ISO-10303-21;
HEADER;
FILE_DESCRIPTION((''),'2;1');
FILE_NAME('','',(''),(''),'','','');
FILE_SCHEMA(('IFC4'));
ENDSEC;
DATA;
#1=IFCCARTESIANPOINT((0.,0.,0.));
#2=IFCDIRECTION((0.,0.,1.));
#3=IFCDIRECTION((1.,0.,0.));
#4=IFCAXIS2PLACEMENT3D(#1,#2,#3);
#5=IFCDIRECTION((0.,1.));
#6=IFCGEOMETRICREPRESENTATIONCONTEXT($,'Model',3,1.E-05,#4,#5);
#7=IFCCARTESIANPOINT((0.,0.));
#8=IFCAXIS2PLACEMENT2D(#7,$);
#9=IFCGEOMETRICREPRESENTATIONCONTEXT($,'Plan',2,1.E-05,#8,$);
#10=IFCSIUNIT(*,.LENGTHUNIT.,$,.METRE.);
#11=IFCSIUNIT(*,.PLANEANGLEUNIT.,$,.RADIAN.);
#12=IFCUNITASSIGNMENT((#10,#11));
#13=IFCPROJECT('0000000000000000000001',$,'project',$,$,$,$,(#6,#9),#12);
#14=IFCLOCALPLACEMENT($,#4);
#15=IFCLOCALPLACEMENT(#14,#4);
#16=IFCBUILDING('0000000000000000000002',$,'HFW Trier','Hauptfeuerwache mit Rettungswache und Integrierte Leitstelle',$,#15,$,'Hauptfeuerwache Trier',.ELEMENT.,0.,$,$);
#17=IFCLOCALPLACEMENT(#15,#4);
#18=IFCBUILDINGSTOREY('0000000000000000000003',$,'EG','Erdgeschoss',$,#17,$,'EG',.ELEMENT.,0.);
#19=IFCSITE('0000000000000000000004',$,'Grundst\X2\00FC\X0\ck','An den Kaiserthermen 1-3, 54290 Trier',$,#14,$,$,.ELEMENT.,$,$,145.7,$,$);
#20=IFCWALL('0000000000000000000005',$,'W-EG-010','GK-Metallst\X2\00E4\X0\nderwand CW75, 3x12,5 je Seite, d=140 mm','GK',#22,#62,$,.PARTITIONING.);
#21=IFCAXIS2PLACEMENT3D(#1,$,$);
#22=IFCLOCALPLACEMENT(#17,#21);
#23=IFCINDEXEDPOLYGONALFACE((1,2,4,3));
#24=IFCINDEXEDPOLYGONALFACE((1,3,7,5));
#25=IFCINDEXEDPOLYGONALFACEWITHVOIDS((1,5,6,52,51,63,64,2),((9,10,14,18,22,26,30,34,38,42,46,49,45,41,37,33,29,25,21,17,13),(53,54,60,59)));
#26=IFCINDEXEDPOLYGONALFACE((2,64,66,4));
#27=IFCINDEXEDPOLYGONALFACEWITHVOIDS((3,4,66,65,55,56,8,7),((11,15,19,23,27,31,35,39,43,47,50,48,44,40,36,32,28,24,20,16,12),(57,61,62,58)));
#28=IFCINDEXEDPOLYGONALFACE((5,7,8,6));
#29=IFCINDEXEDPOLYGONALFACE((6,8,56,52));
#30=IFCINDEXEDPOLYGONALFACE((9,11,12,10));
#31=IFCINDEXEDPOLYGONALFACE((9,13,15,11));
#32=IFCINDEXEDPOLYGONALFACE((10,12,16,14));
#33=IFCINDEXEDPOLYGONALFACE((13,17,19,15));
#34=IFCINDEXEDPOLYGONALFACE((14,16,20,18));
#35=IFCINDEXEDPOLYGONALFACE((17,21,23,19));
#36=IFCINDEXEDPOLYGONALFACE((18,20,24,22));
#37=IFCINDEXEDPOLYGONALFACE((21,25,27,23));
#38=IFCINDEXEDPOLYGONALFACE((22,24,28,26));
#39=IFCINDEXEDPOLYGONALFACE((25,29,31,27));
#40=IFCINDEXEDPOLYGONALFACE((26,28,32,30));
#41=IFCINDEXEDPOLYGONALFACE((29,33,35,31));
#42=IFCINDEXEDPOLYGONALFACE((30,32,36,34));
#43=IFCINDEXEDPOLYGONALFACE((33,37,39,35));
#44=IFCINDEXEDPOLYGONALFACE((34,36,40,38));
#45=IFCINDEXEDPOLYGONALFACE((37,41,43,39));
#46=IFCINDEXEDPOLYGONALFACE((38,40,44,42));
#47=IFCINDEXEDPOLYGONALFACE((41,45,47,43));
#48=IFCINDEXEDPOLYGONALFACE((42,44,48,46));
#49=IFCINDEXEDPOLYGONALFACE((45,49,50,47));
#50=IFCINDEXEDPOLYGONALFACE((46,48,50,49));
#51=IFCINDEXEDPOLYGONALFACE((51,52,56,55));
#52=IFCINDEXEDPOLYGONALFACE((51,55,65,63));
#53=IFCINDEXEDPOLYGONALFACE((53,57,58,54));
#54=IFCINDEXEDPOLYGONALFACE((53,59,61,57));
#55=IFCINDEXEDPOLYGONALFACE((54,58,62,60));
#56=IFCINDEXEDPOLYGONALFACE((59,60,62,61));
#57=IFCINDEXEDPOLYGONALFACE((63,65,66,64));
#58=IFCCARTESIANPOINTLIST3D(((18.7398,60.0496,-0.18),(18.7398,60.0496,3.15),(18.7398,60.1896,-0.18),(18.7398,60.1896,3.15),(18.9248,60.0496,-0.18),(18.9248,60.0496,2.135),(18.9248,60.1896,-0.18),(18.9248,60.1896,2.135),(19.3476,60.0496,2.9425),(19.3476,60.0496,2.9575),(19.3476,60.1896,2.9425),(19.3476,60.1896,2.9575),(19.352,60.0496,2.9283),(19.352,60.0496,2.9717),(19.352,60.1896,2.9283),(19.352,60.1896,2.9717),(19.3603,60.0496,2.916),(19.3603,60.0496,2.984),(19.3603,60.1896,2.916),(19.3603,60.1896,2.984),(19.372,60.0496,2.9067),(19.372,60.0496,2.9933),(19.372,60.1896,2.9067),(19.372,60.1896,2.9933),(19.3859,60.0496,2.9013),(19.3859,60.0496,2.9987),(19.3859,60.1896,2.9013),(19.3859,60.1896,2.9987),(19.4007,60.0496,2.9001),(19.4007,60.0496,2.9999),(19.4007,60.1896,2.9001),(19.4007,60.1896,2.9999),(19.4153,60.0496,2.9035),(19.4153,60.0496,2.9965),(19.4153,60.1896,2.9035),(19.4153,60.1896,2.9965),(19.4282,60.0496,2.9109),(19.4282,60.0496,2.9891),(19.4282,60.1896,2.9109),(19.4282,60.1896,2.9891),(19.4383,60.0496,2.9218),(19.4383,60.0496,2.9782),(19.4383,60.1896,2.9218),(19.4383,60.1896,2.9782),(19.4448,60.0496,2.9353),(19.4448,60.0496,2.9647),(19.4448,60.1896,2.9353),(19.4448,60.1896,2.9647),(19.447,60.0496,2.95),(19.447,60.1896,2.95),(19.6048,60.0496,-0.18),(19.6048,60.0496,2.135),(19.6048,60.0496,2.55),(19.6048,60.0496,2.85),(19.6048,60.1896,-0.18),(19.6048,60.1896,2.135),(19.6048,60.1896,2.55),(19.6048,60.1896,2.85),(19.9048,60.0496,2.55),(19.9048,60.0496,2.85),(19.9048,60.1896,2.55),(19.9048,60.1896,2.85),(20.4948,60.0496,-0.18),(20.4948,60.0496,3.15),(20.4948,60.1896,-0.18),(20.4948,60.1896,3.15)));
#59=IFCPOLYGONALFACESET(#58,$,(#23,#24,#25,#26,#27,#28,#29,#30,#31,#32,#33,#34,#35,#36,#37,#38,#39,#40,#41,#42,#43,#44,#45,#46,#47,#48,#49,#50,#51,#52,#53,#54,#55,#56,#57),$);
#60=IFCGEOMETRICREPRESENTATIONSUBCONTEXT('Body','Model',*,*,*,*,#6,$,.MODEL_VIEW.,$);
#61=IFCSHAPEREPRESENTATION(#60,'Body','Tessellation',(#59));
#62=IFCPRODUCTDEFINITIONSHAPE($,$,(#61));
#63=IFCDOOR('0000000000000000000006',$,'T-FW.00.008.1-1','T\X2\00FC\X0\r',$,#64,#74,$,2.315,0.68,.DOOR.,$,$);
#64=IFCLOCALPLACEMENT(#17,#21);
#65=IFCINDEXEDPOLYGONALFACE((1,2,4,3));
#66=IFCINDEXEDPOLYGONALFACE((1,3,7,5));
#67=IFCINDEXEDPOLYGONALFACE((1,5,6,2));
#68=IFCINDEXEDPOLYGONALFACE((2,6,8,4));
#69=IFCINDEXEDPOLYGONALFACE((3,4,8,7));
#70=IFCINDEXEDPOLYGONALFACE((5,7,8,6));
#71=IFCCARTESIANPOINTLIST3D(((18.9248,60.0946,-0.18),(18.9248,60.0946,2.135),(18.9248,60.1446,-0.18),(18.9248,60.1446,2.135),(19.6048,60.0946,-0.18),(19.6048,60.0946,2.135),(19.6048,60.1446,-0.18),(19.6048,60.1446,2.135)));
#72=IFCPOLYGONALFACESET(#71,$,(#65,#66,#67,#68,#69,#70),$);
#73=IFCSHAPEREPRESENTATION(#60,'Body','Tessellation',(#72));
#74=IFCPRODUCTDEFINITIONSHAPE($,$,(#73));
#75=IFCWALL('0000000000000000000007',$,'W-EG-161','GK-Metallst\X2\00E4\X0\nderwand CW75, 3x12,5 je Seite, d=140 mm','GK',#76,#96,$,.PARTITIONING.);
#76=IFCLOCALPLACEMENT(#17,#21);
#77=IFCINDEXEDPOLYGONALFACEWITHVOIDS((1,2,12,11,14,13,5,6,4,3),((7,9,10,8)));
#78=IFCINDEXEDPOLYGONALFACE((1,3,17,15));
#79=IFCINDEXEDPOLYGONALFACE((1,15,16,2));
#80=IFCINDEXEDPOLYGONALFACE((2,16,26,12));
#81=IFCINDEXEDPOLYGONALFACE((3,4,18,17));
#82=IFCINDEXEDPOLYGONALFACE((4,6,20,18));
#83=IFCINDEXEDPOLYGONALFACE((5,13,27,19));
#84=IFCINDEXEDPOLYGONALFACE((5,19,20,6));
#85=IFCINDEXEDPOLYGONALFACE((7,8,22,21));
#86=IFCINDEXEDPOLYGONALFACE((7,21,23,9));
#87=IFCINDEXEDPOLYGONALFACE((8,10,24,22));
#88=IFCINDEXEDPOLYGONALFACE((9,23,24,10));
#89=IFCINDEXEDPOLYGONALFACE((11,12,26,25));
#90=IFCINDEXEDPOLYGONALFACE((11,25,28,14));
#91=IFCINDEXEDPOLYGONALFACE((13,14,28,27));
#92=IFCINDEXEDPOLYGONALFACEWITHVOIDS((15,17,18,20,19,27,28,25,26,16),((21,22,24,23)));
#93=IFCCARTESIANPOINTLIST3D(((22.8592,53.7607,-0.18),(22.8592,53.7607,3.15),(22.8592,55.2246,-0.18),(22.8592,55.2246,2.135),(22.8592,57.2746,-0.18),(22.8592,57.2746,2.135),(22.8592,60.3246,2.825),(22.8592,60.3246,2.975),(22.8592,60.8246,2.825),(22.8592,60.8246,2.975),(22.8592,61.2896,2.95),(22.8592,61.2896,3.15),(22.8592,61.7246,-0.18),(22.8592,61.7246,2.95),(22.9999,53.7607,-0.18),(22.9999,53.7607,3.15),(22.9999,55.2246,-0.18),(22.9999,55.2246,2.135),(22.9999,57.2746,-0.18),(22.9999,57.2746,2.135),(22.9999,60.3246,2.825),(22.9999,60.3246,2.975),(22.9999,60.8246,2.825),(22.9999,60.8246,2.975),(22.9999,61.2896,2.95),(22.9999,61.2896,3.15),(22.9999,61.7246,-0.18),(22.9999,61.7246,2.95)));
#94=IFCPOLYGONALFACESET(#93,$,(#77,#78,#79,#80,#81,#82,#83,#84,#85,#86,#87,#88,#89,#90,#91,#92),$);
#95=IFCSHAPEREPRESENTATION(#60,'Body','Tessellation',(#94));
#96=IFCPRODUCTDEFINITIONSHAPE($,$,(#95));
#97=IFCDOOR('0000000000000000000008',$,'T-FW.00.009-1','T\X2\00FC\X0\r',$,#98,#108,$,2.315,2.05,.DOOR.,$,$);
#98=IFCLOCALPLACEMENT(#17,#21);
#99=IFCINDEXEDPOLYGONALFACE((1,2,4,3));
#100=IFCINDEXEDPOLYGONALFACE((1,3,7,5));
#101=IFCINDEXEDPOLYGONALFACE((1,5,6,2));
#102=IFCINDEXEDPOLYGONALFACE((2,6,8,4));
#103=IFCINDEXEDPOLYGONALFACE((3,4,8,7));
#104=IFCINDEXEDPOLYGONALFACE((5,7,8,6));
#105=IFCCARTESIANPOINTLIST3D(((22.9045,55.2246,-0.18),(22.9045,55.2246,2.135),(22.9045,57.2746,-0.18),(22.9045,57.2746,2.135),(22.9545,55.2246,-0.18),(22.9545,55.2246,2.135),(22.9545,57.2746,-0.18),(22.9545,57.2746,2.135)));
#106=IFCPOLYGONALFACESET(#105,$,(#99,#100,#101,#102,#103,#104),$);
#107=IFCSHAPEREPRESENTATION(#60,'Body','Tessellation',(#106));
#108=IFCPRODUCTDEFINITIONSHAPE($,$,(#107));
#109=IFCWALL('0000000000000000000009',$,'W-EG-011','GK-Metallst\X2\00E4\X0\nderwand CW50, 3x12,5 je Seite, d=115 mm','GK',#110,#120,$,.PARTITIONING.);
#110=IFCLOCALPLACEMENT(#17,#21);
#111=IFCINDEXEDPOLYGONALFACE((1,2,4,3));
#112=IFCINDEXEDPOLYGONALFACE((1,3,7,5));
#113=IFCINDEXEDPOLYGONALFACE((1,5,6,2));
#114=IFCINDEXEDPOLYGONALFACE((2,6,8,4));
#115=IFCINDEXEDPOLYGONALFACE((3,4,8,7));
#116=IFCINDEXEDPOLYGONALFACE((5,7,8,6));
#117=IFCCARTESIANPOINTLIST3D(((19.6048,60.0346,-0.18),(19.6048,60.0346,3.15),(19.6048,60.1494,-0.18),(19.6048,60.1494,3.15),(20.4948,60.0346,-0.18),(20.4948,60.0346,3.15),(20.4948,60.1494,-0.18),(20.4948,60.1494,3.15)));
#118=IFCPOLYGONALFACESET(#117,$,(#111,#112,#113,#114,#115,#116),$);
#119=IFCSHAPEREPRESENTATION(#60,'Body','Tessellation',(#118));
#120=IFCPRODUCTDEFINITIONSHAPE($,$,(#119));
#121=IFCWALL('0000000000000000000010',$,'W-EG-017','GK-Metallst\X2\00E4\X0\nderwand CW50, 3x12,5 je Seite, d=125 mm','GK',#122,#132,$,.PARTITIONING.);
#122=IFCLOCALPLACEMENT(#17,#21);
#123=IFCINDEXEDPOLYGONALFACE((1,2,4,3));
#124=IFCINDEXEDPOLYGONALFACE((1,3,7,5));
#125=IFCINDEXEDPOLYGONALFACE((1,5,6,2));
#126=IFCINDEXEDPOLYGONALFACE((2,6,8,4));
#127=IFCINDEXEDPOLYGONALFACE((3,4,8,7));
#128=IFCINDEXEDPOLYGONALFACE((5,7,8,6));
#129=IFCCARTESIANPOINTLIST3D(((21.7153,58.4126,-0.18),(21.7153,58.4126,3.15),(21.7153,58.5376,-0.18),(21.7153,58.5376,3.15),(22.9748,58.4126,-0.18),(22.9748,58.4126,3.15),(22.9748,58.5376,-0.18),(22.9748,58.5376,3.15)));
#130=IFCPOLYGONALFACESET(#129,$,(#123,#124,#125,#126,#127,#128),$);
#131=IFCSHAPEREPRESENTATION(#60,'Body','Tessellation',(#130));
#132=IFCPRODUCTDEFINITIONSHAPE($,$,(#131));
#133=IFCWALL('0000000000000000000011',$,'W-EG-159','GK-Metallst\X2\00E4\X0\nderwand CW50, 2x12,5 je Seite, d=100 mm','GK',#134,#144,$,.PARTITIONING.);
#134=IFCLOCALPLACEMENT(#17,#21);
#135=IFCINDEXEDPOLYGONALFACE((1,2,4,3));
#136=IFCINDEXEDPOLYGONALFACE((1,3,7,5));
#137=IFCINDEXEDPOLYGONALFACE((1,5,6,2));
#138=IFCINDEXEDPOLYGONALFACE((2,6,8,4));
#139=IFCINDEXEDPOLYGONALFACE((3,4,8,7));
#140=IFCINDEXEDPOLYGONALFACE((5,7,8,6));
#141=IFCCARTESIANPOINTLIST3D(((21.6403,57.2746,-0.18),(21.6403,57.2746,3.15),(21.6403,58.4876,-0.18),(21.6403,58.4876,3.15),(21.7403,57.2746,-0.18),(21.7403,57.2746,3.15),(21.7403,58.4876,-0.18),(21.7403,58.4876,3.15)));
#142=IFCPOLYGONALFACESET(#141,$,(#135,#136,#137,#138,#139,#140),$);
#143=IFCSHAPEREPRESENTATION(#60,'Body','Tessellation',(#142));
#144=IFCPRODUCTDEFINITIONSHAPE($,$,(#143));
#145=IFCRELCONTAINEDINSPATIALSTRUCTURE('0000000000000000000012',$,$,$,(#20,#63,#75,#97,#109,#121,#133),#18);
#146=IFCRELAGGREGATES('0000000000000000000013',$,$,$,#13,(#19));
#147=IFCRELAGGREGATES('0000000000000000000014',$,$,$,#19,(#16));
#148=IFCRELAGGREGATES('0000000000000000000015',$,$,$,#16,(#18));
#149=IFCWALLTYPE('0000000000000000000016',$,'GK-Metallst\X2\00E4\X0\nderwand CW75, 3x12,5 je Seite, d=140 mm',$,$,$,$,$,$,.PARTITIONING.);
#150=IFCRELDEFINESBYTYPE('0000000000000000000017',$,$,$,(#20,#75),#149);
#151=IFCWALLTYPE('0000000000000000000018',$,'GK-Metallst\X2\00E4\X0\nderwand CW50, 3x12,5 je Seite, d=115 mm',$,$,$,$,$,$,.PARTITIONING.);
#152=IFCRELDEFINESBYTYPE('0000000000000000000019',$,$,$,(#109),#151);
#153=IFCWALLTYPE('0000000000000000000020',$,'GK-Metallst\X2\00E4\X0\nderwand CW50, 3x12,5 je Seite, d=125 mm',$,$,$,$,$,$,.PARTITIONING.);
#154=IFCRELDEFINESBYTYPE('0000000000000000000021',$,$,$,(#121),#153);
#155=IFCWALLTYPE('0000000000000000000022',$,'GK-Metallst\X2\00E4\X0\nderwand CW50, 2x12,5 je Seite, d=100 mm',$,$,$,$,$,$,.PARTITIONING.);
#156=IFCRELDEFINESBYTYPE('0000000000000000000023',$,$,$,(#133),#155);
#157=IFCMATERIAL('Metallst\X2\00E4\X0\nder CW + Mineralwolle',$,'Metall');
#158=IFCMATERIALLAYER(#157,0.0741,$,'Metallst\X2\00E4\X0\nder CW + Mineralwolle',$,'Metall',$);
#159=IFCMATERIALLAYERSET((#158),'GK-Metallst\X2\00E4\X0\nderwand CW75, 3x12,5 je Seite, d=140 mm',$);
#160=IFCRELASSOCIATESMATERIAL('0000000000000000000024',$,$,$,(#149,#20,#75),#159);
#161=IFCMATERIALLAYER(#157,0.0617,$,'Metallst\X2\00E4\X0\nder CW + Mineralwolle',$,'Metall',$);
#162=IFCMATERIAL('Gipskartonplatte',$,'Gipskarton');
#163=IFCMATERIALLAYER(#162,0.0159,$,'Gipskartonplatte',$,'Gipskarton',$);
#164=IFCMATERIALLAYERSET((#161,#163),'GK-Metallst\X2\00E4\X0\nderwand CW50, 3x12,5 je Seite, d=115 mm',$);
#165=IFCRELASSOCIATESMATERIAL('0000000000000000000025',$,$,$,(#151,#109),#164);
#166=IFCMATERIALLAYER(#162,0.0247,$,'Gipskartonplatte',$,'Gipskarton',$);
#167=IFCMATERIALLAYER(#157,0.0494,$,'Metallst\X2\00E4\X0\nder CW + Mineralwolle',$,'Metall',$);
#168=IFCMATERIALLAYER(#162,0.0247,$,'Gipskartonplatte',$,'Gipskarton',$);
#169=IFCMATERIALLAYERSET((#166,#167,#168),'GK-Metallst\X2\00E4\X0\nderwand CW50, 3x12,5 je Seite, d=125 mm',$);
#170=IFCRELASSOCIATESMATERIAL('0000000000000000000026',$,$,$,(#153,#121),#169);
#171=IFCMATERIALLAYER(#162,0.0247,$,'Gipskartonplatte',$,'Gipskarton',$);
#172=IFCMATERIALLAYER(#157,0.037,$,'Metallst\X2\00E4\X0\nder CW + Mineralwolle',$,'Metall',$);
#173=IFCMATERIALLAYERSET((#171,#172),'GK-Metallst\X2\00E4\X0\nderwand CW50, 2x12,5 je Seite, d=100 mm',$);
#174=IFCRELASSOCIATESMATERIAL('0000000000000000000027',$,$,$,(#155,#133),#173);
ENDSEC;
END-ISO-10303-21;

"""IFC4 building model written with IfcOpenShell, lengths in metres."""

from ifc_helpers import new_model, si_unit, direction, frame, frame_2d, origin_with_axes, origin_2d, place, context, subcontext, project, spatial, rectangle, circle, extrude, material, layer, layer_set, layer_usage, type_object, element, fill, save


model = new_model("IFC4")

# Units and contexts
model_context = context("Model", 3, precision=1e-05, world=origin_with_axes(), true_north=direction((0.0, 1.0)))
plan_context = context("Plan", 2, precision=1e-05, world=origin_2d())
body_context = subcontext(model_context, "Body", "Model", "MODEL_VIEW")
ifc_project = project(units=[si_unit("LENGTHUNIT", "METRE"), si_unit("PLANEANGLEUNIT", "RADIAN")], contexts=[model_context, plan_context])

# Site, building, storey
site_placement = place(None, origin_with_axes())
site = spatial("IfcSite", under=ifc_project, at=site_placement, Name="Grundstück", Description="An den Kaiserthermen 1-3, 54290 Trier", CompositionType="ELEMENT", RefElevation=145.7)
building_placement = place(site_placement, origin_with_axes())
building = spatial("IfcBuilding", under=site, at=building_placement, Name="HFW Trier", Description="Hauptfeuerwache mit Rettungswache und Integrierte Leitstelle", LongName="Hauptfeuerwache Trier", CompositionType="ELEMENT", ElevationOfRefHeight=0.0)
storey_placement = place(building_placement, origin_with_axes())
storey = spatial("IfcBuildingStorey", under=building, at=storey_placement, Name="EG", Description="Erdgeschoss", LongName="EG", CompositionType="ELEMENT", Elevation=0.0)

# Shared definitions
ifc_material_1 = material(Name="Gipskartonplatte", Category="Gipskarton")
ifc_material_2 = material(Name="Metallständer CW + Mineralwolle", Category="Metall")

# Walls, openings, doors
ifc_layer_1 = layer(ifc_material_2, 0.0741, Name="Metallständer CW + Mineralwolle", Category="Metall")
ifc_layer_set_1 = layer_set([ifc_layer_1], Name="GK-Metallständerwand CW75, 3x12,5 je Seite, d=140 mm")
ifc_layer_usage_1 = layer_usage(ifc_layer_set_1, "AXIS2", "POSITIVE", -0.0699)
wall_type_1 = type_object("IfcWallType", Name="GK-Metallständerwand CW75, 3x12,5 je Seite, d=140 mm", PredefinedType="PARTITIONING", material=ifc_layer_set_1)
wall_1_placement = place(storey_placement, frame((18.7398, 60.1196, -0.18), z_axis=(0.0, 0.0, 1.0), x_axis=(1.0, 0.0, 0.0)))
wall_1 = element("IfcWall", 1, at=wall_1_placement, inside=storey, type_object=wall_type_1, material=ifc_layer_usage_1, Name="W-EG-010", Description="GK-Metallständerwand CW75, 3x12,5 je Seite, d=140 mm", ObjectType="GK", PredefinedType="PARTITIONING", context=body_context, shape_type="SweptSolid", body=[
    extrude(rectangle(XDim=1.755, YDim=0.1399, at=frame_2d((0.8775, 0.0))), origin_with_axes(), (0.0, 0.0, 1.0), 3.33),
])
opening_1_placement = place(wall_1_placement, frame((0.185, 0.0, 0.0), z_axis=(0.0, 0.0, 1.0), x_axis=(1.0, 0.0, 0.0)))
opening_1 = element("IfcOpeningElement", 2, at=opening_1_placement, cuts=wall_1, PredefinedType="OPENING", context=body_context, shape_type="SweptSolid", body=[
    extrude(rectangle(XDim=0.68, YDim=0.2399, at=frame_2d((0.34, 0.0))), origin_with_axes(), (0.0, 0.0, 1.0), 2.315),
])
opening_2_placement = place(wall_1_placement, origin_with_axes())
element("IfcOpeningElement", 3, at=opening_2_placement, cuts=wall_1, ObjectType="Wanddurchbruch", PredefinedType="OPENING", context=body_context, shape_type="SweptSolid", body=[
    extrude(circle(Radius=0.05, at=origin_2d()), frame((0.6572, -0.12, 3.13), z_axis=(0.0, 1.0, 0.0), x_axis=(1.0, 0.0, 0.0)), (0.0, 0.0, 1.0), 0.2399),
])
opening_3_placement = place(wall_1_placement, origin_with_axes())
element("IfcOpeningElement", 4, at=opening_3_placement, cuts=wall_1, ObjectType="Wanddurchbruch", PredefinedType="OPENING", context=body_context, shape_type="SweptSolid", body=[
    extrude(rectangle(XDim=0.3, YDim=0.2399, at=frame_2d((1.015, 0.0))), frame((0.0, 0.0, 2.73), z_axis=(0.0, 0.0, 1.0), x_axis=(1.0, 0.0, 0.0)), (0.0, 0.0, 1.0), 0.3),
])
door_1_placement = place(wall_1_placement, frame((0.185, 0.0, 0.0), z_axis=(0.0, 0.0, 1.0), x_axis=(1.0, 0.0, 0.0)))
door_1 = element("IfcDoor", 5, at=door_1_placement, inside=storey, Name="T-FW.00.008.1-1", Description="Tür", OverallHeight=2.315, OverallWidth=0.68, PredefinedType="DOOR", context=body_context, shape_type="SweptSolid", body=[
    extrude(rectangle(XDim=0.68, YDim=0.05, at=frame_2d((0.34, 0.0))), origin_with_axes(), (0.0, 0.0, 1.0), 2.315),
])
fill(opening_1, door_1)
ifc_layer_usage_2 = layer_usage(ifc_layer_set_1, "AXIS2", "POSITIVE", -0.0703)
wall_2_placement = place(storey_placement, frame((22.9295, 61.7246, -0.18), z_axis=(0.0, 0.0, 1.0), x_axis=(0.0, -1.0, 0.0)))
wall_2 = element("IfcWall", 6, at=wall_2_placement, inside=storey, type_object=wall_type_1, material=ifc_layer_usage_2, Name="W-EG-161", Description="GK-Metallständerwand CW75, 3x12,5 je Seite, d=140 mm", ObjectType="GK", PredefinedType="PARTITIONING", context=body_context, shape_type="SweptSolid", body=[
    extrude(rectangle(XDim=7.9639, YDim=0.1407, at=frame_2d((3.982, 0.0))), origin_with_axes(), (0.0, 0.0, 1.0), 3.33),
])
opening_4_placement = place(wall_2_placement, frame((4.45, 0.0, 0.0), z_axis=(0.0, 0.0, 1.0), x_axis=(1.0, 0.0, 0.0)))
opening_4 = element("IfcOpeningElement", 7, at=opening_4_placement, cuts=wall_2, PredefinedType="OPENING", context=body_context, shape_type="SweptSolid", body=[
    extrude(rectangle(XDim=2.05, YDim=0.2407, at=frame_2d((1.025, 0.0))), origin_with_axes(), (0.0, 0.0, 1.0), 2.315),
])
opening_5_placement = place(wall_2_placement, origin_with_axes())
element("IfcOpeningElement", 8, at=opening_5_placement, cuts=wall_2, ObjectType="Wanddurchbruch", PredefinedType="OPENING", context=body_context, shape_type="SweptSolid", body=[
    extrude(rectangle(XDim=0.5, YDim=0.2407, at=frame_2d((1.15, 0.0))), frame((0.0, 0.0, 3.005), z_axis=(0.0, 0.0, 1.0), x_axis=(1.0, 0.0, 0.0)), (0.0, 0.0, 1.0), 0.15),
])
opening_6_placement = place(wall_2_placement, origin_with_axes())
element("IfcOpeningElement", 9, at=opening_6_placement, cuts=wall_2, ObjectType="Wanddurchbruch", PredefinedType="OPENING", context=body_context, shape_type="SweptSolid", body=[
    extrude(rectangle(XDim=0.435, YDim=0.2407, at=frame_2d((0.2175, 0.0))), frame((0.0, 0.0, 3.13), z_axis=(0.0, 0.0, 1.0), x_axis=(1.0, 0.0, 0.0)), (0.0, 0.0, 1.0), 0.2),
])
door_2_placement = place(wall_2_placement, frame((4.45, 0.0, 0.0), z_axis=(0.0, 0.0, 1.0), x_axis=(1.0, 0.0, 0.0)))
door_2 = element("IfcDoor", 10, at=door_2_placement, inside=storey, Name="T-FW.00.009-1", Description="Tür", OverallHeight=2.315, OverallWidth=2.05, PredefinedType="DOOR", context=body_context, shape_type="SweptSolid", body=[
    extrude(rectangle(XDim=2.05, YDim=0.05, at=frame_2d((1.025, 0.0))), origin_with_axes(), (0.0, 0.0, 1.0), 2.315),
])
fill(opening_4, door_2)

# Walls
ifc_layer_2 = layer(ifc_material_2, 0.0617, Name="Metallständer CW + Mineralwolle", Category="Metall")
ifc_layer_3 = layer(ifc_material_1, 0.0159, Name="Gipskartonplatte", Category="Gipskarton")
ifc_layer_set_2 = layer_set([ifc_layer_2, ifc_layer_3], Name="GK-Metallständerwand CW50, 3x12,5 je Seite, d=115 mm")
ifc_layer_usage_3 = layer_usage(ifc_layer_set_2, "AXIS2", "POSITIVE", -0.0575)
wall_type_2 = type_object("IfcWallType", Name="GK-Metallständerwand CW50, 3x12,5 je Seite, d=115 mm", PredefinedType="PARTITIONING", material=ifc_layer_set_2)
wall_3_placement = place(storey_placement, frame((19.6048, 60.092, -0.18), z_axis=(0.0, 0.0, 1.0), x_axis=(1.0, 0.0, 0.0)))
element("IfcWall", 11, at=wall_3_placement, inside=storey, type_object=wall_type_2, material=ifc_layer_usage_3, Name="W-EG-011", Description="GK-Metallständerwand CW50, 3x12,5 je Seite, d=115 mm", ObjectType="GK", PredefinedType="PARTITIONING", context=body_context, shape_type="SweptSolid", body=[
    extrude(rectangle(XDim=0.89, YDim=0.1149, at=frame_2d((0.445, 0.0))), origin_with_axes(), (0.0, 0.0, 1.0), 3.33),
])
ifc_layer_4 = layer(ifc_material_1, 0.0247, Name="Gipskartonplatte", Category="Gipskarton")
ifc_layer_5 = layer(ifc_material_2, 0.0494, Name="Metallständer CW + Mineralwolle", Category="Metall")
ifc_layer_6 = layer(ifc_material_1, 0.0247, Name="Gipskartonplatte", Category="Gipskarton")
ifc_layer_set_3 = layer_set([ifc_layer_4, ifc_layer_5, ifc_layer_6], Name="GK-Metallständerwand CW50, 3x12,5 je Seite, d=125 mm")
ifc_layer_usage_4 = layer_usage(ifc_layer_set_3, "AXIS2", "POSITIVE", -0.0625)
wall_type_3 = type_object("IfcWallType", Name="GK-Metallständerwand CW50, 3x12,5 je Seite, d=125 mm", PredefinedType="PARTITIONING", material=ifc_layer_set_3)
wall_4_placement = place(storey_placement, frame((21.7153, 58.4751, -0.18), z_axis=(0.0, 0.0, 1.0), x_axis=(1.0, 0.0, 0.0)))
element("IfcWall", 12, at=wall_4_placement, inside=storey, type_object=wall_type_3, material=ifc_layer_usage_4, Name="W-EG-017", Description="GK-Metallständerwand CW50, 3x12,5 je Seite, d=125 mm", ObjectType="GK", PredefinedType="PARTITIONING", context=body_context, shape_type="SweptSolid", body=[
    extrude(rectangle(XDim=1.2595, YDim=0.1251, at=frame_2d((0.6297, 0.0))), origin_with_axes(), (0.0, 0.0, 1.0), 3.33),
])
ifc_layer_7 = layer(ifc_material_1, 0.0247, Name="Gipskartonplatte", Category="Gipskarton")
ifc_layer_8 = layer(ifc_material_2, 0.037, Name="Metallständer CW + Mineralwolle", Category="Metall")
ifc_layer_set_4 = layer_set([ifc_layer_7, ifc_layer_8], Name="GK-Metallständerwand CW50, 2x12,5 je Seite, d=100 mm")
ifc_layer_usage_5 = layer_usage(ifc_layer_set_4, "AXIS2", "POSITIVE", -0.05)
wall_type_4 = type_object("IfcWallType", Name="GK-Metallständerwand CW50, 2x12,5 je Seite, d=100 mm", PredefinedType="PARTITIONING", material=ifc_layer_set_4)
wall_5_placement = place(storey_placement, frame((21.6903, 58.4876, -0.18), z_axis=(0.0, 0.0, 1.0), x_axis=(0.0, -1.0, 0.0)))
element("IfcWall", 13, at=wall_5_placement, inside=storey, type_object=wall_type_4, material=ifc_layer_usage_5, Name="W-EG-159", Description="GK-Metallständerwand CW50, 2x12,5 je Seite, d=100 mm", ObjectType="GK", PredefinedType="PARTITIONING", context=body_context, shape_type="SweptSolid", body=[
    extrude(rectangle(XDim=1.213, YDim=0.1, at=frame_2d((0.6065, 0.0))), origin_with_axes(), (0.0, 0.0, 1.0), 3.33),
])

save(model, "model.ifc")
